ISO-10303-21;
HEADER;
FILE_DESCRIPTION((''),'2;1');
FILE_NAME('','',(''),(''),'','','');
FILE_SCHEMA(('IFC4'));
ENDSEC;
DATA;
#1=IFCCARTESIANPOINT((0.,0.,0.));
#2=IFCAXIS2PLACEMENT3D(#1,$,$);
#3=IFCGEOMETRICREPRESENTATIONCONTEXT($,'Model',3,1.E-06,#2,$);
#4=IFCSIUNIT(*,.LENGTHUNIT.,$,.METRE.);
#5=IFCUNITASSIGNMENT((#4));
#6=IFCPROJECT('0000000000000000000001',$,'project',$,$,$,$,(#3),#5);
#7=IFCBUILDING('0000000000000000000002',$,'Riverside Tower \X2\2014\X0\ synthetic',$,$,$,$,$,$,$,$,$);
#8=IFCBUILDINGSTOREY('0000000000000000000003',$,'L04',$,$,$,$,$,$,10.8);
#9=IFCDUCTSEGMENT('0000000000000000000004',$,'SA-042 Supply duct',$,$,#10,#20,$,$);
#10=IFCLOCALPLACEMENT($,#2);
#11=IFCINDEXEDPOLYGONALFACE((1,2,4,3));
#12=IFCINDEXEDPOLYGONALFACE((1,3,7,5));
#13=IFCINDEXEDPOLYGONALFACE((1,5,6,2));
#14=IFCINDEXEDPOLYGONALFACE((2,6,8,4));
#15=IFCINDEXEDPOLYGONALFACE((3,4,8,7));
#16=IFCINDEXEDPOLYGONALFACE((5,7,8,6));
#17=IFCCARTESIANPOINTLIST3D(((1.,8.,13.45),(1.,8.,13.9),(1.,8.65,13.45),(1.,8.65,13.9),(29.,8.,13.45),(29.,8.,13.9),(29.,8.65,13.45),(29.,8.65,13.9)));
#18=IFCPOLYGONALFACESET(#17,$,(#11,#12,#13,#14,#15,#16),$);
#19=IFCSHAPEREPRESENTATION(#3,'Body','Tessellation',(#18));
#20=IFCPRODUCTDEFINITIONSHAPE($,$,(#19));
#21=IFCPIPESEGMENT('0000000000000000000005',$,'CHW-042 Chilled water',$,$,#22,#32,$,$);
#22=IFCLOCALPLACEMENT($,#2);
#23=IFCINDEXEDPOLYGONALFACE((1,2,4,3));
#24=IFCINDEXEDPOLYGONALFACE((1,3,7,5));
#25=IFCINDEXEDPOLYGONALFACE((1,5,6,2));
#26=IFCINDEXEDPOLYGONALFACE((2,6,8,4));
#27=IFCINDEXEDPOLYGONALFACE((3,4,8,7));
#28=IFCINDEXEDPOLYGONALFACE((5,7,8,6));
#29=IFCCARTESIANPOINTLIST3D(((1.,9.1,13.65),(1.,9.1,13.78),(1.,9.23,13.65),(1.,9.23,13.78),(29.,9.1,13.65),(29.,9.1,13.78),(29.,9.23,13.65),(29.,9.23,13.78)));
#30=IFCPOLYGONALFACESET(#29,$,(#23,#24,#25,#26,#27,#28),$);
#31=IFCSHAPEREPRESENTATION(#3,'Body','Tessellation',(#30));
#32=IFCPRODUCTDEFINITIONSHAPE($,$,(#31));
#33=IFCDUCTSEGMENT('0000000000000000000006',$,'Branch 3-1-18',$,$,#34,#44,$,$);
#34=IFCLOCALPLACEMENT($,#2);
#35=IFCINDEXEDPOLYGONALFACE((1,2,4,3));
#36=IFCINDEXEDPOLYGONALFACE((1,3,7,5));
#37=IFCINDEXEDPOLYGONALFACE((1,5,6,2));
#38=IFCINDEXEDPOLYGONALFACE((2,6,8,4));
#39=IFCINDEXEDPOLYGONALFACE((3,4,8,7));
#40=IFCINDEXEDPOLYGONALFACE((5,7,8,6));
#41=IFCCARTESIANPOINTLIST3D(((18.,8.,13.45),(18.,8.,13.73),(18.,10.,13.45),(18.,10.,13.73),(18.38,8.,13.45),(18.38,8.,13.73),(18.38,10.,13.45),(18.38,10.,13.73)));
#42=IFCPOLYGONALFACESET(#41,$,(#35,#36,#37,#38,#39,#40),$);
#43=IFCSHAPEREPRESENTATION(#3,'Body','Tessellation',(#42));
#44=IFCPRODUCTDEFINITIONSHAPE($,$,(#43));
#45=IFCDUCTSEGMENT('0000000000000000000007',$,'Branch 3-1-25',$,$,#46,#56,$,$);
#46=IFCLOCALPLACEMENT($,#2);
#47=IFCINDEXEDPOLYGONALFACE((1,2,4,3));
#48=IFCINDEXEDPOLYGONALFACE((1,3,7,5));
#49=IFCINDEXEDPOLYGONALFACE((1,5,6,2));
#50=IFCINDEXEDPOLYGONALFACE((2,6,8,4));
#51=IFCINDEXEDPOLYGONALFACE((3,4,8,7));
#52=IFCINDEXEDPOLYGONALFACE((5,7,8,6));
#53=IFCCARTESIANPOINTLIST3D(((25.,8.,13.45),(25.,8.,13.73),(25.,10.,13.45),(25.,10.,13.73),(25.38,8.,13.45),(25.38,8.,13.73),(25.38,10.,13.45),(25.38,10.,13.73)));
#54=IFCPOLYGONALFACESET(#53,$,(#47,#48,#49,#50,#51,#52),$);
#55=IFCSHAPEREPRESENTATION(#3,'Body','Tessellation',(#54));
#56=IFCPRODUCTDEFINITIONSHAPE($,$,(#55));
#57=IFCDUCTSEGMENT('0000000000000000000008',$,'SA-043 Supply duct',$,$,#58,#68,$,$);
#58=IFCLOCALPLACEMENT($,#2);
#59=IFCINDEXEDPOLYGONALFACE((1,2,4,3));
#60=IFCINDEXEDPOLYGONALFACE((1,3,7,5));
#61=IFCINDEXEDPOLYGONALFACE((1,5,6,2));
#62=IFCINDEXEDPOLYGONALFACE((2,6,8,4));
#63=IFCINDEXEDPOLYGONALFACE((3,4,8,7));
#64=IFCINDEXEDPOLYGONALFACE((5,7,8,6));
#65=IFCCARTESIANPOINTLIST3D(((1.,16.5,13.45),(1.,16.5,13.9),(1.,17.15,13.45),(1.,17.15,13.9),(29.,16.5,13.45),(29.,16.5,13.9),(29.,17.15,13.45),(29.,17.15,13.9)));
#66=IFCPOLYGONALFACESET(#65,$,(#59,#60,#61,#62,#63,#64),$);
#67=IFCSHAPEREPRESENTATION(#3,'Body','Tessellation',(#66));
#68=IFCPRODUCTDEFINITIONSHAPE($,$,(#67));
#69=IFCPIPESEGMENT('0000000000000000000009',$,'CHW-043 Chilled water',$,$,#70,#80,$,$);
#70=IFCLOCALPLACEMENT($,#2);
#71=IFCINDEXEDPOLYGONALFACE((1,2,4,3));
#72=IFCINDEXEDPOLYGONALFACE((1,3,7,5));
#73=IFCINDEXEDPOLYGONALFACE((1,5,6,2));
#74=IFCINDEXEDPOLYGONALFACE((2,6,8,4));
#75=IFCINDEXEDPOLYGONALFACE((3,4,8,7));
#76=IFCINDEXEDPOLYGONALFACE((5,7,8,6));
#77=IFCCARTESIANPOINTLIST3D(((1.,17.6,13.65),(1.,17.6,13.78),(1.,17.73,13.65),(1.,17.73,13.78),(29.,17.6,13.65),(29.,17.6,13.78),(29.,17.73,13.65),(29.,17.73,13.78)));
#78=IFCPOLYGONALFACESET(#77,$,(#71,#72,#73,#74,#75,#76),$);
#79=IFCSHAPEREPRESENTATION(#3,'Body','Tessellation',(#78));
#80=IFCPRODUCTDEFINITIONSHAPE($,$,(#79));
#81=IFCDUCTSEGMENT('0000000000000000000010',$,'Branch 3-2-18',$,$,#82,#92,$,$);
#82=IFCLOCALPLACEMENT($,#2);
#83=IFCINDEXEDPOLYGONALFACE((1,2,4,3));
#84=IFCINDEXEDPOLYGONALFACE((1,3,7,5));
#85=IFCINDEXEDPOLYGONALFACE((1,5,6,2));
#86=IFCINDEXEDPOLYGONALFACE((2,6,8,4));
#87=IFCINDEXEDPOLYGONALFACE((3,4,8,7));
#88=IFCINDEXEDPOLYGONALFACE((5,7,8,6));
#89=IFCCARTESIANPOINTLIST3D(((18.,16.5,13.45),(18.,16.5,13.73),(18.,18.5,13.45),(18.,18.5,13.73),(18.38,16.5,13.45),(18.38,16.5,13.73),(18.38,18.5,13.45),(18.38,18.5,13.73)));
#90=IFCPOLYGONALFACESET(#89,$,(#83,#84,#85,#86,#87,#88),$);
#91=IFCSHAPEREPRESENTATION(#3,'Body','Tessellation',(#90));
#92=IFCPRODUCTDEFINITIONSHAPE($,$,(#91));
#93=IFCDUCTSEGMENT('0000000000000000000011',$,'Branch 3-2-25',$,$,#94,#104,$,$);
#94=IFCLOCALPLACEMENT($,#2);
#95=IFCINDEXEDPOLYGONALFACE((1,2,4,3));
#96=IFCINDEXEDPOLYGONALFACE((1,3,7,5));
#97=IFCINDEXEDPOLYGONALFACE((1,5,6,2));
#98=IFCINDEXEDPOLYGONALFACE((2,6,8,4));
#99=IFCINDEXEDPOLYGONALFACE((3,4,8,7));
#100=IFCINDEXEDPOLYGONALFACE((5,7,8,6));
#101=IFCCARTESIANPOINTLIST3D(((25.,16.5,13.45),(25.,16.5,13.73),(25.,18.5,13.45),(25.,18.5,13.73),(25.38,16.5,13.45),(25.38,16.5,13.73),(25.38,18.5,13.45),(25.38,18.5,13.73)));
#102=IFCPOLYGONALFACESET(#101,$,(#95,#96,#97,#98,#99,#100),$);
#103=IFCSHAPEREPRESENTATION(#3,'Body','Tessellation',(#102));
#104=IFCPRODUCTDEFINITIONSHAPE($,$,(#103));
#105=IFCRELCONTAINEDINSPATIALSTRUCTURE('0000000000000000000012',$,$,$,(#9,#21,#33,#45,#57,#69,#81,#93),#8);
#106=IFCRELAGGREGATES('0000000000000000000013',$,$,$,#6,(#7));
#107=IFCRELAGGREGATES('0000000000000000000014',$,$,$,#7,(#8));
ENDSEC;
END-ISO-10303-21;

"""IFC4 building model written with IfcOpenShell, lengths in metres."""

from ifc_helpers import new_model, si_unit, frame, origin, place, context, project, spatial, rectangle, extrude, element, save


model = new_model("IFC4")

# Units and contexts
model_context = context("Model", 3, precision=1e-06, world=origin())
ifc_project = project(units=[si_unit("LENGTHUNIT", "METRE")], contexts=[model_context])

# Building, storey
building = spatial("IfcBuilding", under=ifc_project, Name="Riverside Tower — synthetic")
storey = spatial("IfcBuildingStorey", under=building, Name="L04", Elevation=10.8)

# Duct segment
duct_segment_1_placement = place(None, frame((15.0, 8.325, 13.45)))
element("IfcDuctSegment", 1, at=duct_segment_1_placement, inside=storey, Name="SA-042 Supply duct", context=model_context, shape_type="SweptSolid", body=[
    extrude(rectangle(XDim=28.0, YDim=0.65), origin(), (0.0, 0.0, 1.0), 0.45),
])

# Pipe segment
pipe_segment_1_placement = place(None, frame((15.0, 9.165, 13.65)))
element("IfcPipeSegment", 2, at=pipe_segment_1_placement, inside=storey, Name="CHW-042 Chilled water", context=model_context, shape_type="SweptSolid", body=[
    extrude(rectangle(XDim=28.0, YDim=0.13), origin(), (0.0, 0.0, 1.0), 0.13),
])

# Duct segments
for number, where, name in (
    (3, (18.19, 9.0, 13.45), "Branch 3-1-18"),
    (4, (25.19, 9.0, 13.45), "Branch 3-1-25"),
):
    element("IfcDuctSegment", number, at=place(None, frame(where)), inside=storey, Name=name, context=model_context, shape_type="SweptSolid", body=[
        extrude(rectangle(XDim=0.38, YDim=2.0), origin(), (0.0, 0.0, 1.0), 0.28),
    ])
duct_segment_2_placement = place(None, frame((15.0, 16.825, 13.45)))
element("IfcDuctSegment", 5, at=duct_segment_2_placement, inside=storey, Name="SA-043 Supply duct", context=model_context, shape_type="SweptSolid", body=[
    extrude(rectangle(XDim=28.0, YDim=0.65), origin(), (0.0, 0.0, 1.0), 0.45),
])

# Pipe segment
pipe_segment_2_placement = place(None, frame((15.0, 17.665, 13.65)))
element("IfcPipeSegment", 6, at=pipe_segment_2_placement, inside=storey, Name="CHW-043 Chilled water", context=model_context, shape_type="SweptSolid", body=[
    extrude(rectangle(XDim=28.0, YDim=0.13), origin(), (0.0, 0.0, 1.0), 0.13),
])

# Duct segments
for number, where, name in (
    (7, (18.19, 17.5, 13.45), "Branch 3-2-18"),
    (8, (25.19, 17.5, 13.45), "Branch 3-2-25"),
):
    element("IfcDuctSegment", number, at=place(None, frame(where)), inside=storey, Name=name, context=model_context, shape_type="SweptSolid", body=[
        extrude(rectangle(XDim=0.38, YDim=2.0), origin(), (0.0, 0.0, 1.0), 0.28),
    ])

save(model, "model.ifc")
